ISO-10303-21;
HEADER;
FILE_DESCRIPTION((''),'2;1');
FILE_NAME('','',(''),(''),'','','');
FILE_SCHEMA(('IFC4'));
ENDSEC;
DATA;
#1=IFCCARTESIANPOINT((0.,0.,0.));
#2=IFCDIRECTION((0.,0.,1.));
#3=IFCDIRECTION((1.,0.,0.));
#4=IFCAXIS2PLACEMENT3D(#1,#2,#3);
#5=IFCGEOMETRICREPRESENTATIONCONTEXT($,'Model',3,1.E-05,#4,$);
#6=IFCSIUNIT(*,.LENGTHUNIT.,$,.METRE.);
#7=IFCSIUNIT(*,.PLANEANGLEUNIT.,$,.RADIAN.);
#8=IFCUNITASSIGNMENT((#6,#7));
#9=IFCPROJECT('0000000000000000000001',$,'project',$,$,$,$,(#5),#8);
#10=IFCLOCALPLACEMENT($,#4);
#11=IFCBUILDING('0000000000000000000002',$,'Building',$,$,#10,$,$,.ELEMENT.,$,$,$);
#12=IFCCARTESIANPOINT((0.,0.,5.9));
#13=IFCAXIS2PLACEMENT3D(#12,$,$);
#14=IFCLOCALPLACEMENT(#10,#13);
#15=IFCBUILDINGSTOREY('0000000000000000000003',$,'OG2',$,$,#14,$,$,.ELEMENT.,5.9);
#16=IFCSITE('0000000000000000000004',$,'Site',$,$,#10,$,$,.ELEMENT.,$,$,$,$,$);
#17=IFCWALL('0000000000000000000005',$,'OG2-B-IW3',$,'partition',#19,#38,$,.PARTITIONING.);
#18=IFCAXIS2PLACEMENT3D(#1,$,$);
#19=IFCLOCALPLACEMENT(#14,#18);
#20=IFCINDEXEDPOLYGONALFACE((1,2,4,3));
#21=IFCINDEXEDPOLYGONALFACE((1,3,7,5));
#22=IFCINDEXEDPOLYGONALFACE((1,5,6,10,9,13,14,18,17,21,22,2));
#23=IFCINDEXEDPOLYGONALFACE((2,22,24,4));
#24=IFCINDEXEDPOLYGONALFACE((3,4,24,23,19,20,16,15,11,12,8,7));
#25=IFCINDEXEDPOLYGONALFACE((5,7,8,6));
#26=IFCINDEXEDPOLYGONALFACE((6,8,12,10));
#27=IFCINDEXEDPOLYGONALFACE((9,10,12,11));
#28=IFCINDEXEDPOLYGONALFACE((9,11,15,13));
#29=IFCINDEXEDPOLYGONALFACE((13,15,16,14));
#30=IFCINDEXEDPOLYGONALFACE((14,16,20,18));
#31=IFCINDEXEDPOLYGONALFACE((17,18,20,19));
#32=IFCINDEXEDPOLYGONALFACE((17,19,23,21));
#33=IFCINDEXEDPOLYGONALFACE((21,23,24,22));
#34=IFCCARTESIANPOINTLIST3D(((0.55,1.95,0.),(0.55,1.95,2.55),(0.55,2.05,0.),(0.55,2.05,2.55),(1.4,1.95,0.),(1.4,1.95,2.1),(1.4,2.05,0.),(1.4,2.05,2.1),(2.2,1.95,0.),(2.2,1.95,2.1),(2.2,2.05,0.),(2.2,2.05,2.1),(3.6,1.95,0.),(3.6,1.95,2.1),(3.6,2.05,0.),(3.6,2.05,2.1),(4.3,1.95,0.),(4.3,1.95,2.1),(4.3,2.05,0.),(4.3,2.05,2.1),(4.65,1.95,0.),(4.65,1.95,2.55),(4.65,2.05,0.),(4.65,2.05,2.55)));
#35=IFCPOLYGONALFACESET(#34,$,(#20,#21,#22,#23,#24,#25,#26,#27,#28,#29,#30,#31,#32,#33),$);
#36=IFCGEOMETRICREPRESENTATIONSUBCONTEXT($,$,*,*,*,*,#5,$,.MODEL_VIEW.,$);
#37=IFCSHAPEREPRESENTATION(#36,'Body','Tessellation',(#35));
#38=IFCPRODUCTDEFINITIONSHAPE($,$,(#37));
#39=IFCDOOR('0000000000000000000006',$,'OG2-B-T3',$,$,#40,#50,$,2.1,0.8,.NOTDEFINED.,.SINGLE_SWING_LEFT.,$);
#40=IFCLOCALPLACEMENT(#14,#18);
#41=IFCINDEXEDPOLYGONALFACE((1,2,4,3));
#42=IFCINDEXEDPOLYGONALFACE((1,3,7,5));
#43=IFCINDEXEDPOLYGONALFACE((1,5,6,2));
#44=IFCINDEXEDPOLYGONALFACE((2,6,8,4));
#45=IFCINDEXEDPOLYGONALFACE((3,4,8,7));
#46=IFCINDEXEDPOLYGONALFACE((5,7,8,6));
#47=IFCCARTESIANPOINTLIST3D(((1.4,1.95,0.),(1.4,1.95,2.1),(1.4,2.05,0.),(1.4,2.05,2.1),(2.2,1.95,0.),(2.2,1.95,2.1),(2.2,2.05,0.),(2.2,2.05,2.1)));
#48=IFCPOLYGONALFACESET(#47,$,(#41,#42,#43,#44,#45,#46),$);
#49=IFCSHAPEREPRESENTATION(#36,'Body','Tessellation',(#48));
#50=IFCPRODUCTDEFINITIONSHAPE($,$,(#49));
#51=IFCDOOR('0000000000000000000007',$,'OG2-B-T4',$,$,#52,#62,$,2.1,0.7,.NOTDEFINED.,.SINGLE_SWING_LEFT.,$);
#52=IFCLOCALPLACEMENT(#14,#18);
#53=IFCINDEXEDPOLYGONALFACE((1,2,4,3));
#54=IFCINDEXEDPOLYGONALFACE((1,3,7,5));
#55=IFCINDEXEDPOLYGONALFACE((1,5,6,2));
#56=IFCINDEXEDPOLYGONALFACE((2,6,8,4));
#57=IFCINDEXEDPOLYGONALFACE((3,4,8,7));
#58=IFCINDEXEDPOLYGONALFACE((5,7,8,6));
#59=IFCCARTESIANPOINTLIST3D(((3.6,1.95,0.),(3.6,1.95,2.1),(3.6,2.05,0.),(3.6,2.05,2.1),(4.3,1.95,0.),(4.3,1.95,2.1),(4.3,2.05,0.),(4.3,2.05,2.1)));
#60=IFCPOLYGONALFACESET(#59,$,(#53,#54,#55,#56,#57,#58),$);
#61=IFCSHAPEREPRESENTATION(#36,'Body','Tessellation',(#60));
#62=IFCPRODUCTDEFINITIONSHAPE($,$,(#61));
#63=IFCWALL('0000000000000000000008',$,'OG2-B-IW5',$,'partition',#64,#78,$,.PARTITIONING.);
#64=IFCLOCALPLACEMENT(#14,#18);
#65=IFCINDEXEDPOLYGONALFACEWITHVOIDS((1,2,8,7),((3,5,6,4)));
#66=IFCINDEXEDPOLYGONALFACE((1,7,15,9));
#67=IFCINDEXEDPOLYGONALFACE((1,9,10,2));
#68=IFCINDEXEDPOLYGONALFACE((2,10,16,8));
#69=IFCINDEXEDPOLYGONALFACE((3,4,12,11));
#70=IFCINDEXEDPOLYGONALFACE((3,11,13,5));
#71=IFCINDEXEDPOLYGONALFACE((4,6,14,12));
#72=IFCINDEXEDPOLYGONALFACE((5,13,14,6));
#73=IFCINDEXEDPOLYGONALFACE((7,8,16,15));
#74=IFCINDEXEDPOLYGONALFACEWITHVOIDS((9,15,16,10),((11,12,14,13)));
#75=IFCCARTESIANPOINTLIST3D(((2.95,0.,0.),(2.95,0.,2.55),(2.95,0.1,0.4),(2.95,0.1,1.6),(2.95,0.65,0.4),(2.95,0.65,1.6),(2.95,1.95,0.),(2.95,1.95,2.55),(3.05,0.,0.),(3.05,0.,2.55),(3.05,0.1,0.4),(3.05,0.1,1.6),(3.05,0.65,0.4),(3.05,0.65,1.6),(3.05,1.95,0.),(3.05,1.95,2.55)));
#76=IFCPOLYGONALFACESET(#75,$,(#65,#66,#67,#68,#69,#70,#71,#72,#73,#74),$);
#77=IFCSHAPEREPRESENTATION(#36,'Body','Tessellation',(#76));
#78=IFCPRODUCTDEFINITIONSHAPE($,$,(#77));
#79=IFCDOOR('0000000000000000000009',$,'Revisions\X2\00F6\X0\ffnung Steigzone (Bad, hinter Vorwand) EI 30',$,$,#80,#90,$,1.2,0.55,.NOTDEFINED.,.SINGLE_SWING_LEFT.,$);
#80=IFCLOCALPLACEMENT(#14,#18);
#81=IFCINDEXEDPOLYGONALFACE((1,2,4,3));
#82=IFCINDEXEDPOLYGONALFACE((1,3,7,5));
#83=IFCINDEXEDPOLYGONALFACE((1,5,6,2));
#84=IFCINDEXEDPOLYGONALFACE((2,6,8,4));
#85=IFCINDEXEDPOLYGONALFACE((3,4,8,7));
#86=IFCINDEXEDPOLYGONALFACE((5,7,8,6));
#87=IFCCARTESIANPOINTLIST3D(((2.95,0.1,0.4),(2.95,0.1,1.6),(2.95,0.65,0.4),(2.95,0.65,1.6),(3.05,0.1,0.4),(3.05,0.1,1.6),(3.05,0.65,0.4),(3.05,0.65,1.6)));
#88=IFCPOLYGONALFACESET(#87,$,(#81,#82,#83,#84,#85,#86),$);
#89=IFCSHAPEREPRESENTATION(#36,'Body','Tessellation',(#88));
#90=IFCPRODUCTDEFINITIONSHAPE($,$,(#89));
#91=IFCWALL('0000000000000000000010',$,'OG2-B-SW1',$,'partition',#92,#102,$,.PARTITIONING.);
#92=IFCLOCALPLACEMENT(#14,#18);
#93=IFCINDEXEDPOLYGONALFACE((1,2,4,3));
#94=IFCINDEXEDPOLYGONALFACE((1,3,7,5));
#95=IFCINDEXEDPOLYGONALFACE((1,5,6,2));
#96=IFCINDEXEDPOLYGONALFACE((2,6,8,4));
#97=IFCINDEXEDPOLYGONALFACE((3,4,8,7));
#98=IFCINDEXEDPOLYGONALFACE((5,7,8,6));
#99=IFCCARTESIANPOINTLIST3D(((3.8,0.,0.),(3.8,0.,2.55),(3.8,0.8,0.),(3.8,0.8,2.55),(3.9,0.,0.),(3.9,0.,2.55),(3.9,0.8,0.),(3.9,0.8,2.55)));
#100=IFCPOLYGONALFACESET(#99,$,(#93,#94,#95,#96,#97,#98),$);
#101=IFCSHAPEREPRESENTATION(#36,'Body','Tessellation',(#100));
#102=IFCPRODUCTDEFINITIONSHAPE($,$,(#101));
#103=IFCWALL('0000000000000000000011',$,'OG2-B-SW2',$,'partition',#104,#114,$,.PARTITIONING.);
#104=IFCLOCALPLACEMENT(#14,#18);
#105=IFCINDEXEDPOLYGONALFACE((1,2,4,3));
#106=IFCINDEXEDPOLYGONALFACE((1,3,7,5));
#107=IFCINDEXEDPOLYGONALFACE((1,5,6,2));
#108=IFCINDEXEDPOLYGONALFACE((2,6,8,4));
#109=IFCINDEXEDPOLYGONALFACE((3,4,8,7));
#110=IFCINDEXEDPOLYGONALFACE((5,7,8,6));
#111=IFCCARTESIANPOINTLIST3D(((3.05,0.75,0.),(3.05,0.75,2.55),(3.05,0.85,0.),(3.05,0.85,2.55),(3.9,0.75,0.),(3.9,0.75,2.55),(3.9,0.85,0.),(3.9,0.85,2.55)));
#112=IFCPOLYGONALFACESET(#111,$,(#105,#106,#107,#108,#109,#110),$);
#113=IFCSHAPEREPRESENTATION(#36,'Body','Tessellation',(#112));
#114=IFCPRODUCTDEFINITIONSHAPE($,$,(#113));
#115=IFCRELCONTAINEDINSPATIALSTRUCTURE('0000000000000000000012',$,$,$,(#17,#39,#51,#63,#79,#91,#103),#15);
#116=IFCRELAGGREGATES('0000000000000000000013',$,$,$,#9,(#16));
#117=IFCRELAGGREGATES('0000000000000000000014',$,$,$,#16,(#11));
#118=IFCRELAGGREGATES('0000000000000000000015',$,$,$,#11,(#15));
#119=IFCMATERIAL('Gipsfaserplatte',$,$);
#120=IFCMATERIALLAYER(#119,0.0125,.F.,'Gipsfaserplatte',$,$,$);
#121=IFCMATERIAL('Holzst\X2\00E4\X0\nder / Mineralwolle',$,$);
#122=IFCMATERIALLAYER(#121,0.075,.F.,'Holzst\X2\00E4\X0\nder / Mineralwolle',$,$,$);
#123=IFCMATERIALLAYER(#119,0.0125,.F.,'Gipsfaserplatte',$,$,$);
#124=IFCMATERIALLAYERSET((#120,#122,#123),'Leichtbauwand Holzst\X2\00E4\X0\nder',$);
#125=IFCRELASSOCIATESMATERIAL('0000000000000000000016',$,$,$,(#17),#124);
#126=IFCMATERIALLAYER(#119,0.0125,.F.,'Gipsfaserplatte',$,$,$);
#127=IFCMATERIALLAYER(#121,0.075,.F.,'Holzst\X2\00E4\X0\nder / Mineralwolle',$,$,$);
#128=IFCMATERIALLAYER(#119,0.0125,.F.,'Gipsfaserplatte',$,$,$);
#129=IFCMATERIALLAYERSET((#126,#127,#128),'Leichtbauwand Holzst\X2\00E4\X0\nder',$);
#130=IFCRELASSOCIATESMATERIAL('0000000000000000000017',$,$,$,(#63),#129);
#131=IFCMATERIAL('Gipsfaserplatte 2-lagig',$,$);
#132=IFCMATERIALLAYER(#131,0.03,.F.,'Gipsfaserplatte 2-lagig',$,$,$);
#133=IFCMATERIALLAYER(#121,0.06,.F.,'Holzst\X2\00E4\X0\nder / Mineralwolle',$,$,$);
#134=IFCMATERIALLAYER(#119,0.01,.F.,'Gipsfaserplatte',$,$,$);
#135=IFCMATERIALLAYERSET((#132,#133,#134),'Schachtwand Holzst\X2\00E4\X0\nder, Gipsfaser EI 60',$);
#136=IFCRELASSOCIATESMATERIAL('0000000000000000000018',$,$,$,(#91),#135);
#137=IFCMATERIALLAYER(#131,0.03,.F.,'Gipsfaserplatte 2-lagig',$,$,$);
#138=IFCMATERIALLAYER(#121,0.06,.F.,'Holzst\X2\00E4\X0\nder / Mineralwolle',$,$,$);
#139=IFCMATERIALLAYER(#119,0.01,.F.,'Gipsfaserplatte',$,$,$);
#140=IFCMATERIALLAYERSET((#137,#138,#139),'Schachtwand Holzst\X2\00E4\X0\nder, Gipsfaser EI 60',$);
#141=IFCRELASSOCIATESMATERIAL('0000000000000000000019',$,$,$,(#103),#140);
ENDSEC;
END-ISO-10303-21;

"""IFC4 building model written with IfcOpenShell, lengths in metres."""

from ifc_helpers import new_model, si_unit, frame, frame_2d, origin, origin_with_axes, place, context, subcontext, project, spatial, rectangle, extrude, material, layer, layer_set, element, fill, save


model = new_model("IFC4")

# Units and contexts
model_context = context("Model", 3, precision=1e-05, world=origin_with_axes())
sub_context = subcontext(model_context, None, None, "MODEL_VIEW")
ifc_project = project(units=[si_unit("LENGTHUNIT", "METRE"), si_unit("PLANEANGLEUNIT", "RADIAN")], contexts=[model_context])

# Site, building, storey
placement = place(None, origin_with_axes())
site = spatial("IfcSite", under=ifc_project, at=placement, Name="Site", CompositionType="ELEMENT")
building = spatial("IfcBuilding", under=site, at=placement, Name="Building", CompositionType="ELEMENT")
storey_placement = place(placement, frame((0.0, 0.0, 5.9)))
storey = spatial("IfcBuildingStorey", under=building, at=storey_placement, Name="OG2", CompositionType="ELEMENT", Elevation=5.9)

# Shared definitions
ifc_material_1 = material(Name="Gipsfaserplatte")

# Shared definitions
ifc_material_2 = material(Name="Gipsfaserplatte 2-lagig")

# Shared definitions
ifc_material_3 = material(Name="Holzständer / Mineralwolle")

# Wall, openings, doors
ifc_layer_1 = layer(ifc_material_1, 0.0125, ventilated=False, Name="Gipsfaserplatte")
ifc_layer_2 = layer(ifc_material_3, 0.075, ventilated=False, Name="Holzständer / Mineralwolle")
ifc_layer_3 = layer(ifc_material_1, 0.0125, ventilated=False, Name="Gipsfaserplatte")
ifc_layer_set_1 = layer_set([ifc_layer_1, ifc_layer_2, ifc_layer_3], Name="Leichtbauwand Holzständer")
wall_1_placement = place(storey_placement, frame((0.55, 2.0, 0.0), z_axis=(0.0, 0.0, 1.0), x_axis=(1.0, 0.0, 0.0)))
wall_1 = element("IfcWall", 1, at=wall_1_placement, inside=storey, material=ifc_layer_set_1, Name="OG2-B-IW3", ObjectType="partition", PredefinedType="PARTITIONING", context=sub_context, shape_type="SweptSolid", body=[
    extrude(rectangle(XDim=4.1, YDim=0.1, at=frame_2d((2.05, 0.0))), origin(), (0.0, 0.0, 1.0), 2.55),
])
opening_1_placement = place(wall_1_placement, frame((1.25, 0.1, 0.0), z_axis=(0.0, -1.0, 0.0), x_axis=(1.0, 0.0, 0.0)))
opening_1 = element("IfcOpeningElement", 2, at=opening_1_placement, cuts=wall_1, PredefinedType="OPENING", context=sub_context, shape_type="SweptSolid", body=[
    extrude(rectangle(XDim=0.8, YDim=2.1, at=frame_2d((0.0, 1.05))), origin(), (0.0, 0.0, 1.0), 0.2),
])
opening_2_placement = place(wall_1_placement, frame((3.4, 0.1, 0.0), z_axis=(0.0, -1.0, 0.0), x_axis=(1.0, 0.0, 0.0)))
opening_2 = element("IfcOpeningElement", 3, at=opening_2_placement, cuts=wall_1, PredefinedType="OPENING", context=sub_context, shape_type="SweptSolid", body=[
    extrude(rectangle(XDim=0.7, YDim=2.1, at=frame_2d((0.0, 1.05))), origin(), (0.0, 0.0, 1.0), 0.2),
])
door_1_placement = place(wall_1_placement, frame((1.25, 0.05, 0.0), z_axis=(0.0, -1.0, 0.0), x_axis=(1.0, 0.0, 0.0)))
door_1 = element("IfcDoor", 4, at=door_1_placement, inside=storey, Name="OG2-B-T3", OperationType="SINGLE_SWING_LEFT", OverallHeight=2.1, OverallWidth=0.8, PredefinedType="NOTDEFINED", context=sub_context, shape_type="SweptSolid", body=[
    extrude(rectangle(XDim=0.8, YDim=2.1, at=frame_2d((0.0, 1.05))), origin(), (0.0, 0.0, 1.0), 0.1),
])
fill(opening_1, door_1)
door_2_placement = place(wall_1_placement, frame((3.4, 0.05, 0.0), z_axis=(0.0, -1.0, 0.0), x_axis=(1.0, 0.0, 0.0)))
door_2 = element("IfcDoor", 5, at=door_2_placement, inside=storey, Name="OG2-B-T4", OperationType="SINGLE_SWING_LEFT", OverallHeight=2.1, OverallWidth=0.7, PredefinedType="NOTDEFINED", context=sub_context, shape_type="SweptSolid", body=[
    extrude(rectangle(XDim=0.7, YDim=2.1, at=frame_2d((0.0, 1.05))), origin(), (0.0, 0.0, 1.0), 0.1),
])
fill(opening_2, door_2)

# Wall, opening, door
ifc_layer_4 = layer(ifc_material_1, 0.0125, ventilated=False, Name="Gipsfaserplatte")
ifc_layer_5 = layer(ifc_material_3, 0.075, ventilated=False, Name="Holzständer / Mineralwolle")
ifc_layer_6 = layer(ifc_material_1, 0.0125, ventilated=False, Name="Gipsfaserplatte")
ifc_layer_set_2 = layer_set([ifc_layer_4, ifc_layer_5, ifc_layer_6], Name="Leichtbauwand Holzständer")
wall_2_placement = place(storey_placement, frame((3.0, 0.0, 0.0), z_axis=(0.0, 0.0, 1.0), x_axis=(0.0, 1.0, 0.0)))
wall_2 = element("IfcWall", 6, at=wall_2_placement, inside=storey, material=ifc_layer_set_2, Name="OG2-B-IW5", ObjectType="partition", PredefinedType="PARTITIONING", context=sub_context, shape_type="SweptSolid", body=[
    extrude(rectangle(XDim=1.95, YDim=0.1, at=frame_2d((0.975, 0.0))), origin(), (0.0, 0.0, 1.0), 2.55),
])
opening_3_placement = place(wall_2_placement, frame((0.375, 0.1, 0.4), z_axis=(0.0, -1.0, 0.0), x_axis=(1.0, 0.0, 0.0)))
opening_3 = element("IfcOpeningElement", 7, at=opening_3_placement, cuts=wall_2, PredefinedType="OPENING", context=sub_context, shape_type="SweptSolid", body=[
    extrude(rectangle(XDim=0.55, YDim=1.2, at=frame_2d((0.0, 0.6))), origin(), (0.0, 0.0, 1.0), 0.2),
])
door_3_placement = place(wall_2_placement, frame((0.375, 0.05, 0.4), z_axis=(0.0, -1.0, 0.0), x_axis=(1.0, 0.0, 0.0)))
door_3 = element("IfcDoor", 8, at=door_3_placement, inside=storey, Name="Revisionsöffnung Steigzone (Bad, hinter Vorwand) EI 30", OperationType="SINGLE_SWING_LEFT", OverallHeight=1.2, OverallWidth=0.55, PredefinedType="NOTDEFINED", context=sub_context, shape_type="SweptSolid", body=[
    extrude(rectangle(XDim=0.55, YDim=1.2, at=frame_2d((0.0, 0.6))), origin(), (0.0, 0.0, 1.0), 0.1),
])
fill(opening_3, door_3)

# Walls
ifc_layer_7 = layer(ifc_material_2, 0.03, ventilated=False, Name="Gipsfaserplatte 2-lagig")
ifc_layer_8 = layer(ifc_material_3, 0.06, ventilated=False, Name="Holzständer / Mineralwolle")
ifc_layer_9 = layer(ifc_material_1, 0.01, ventilated=False, Name="Gipsfaserplatte")
ifc_layer_set_3 = layer_set([ifc_layer_7, ifc_layer_8, ifc_layer_9], Name="Schachtwand Holzständer, Gipsfaser EI 60")
wall_3_placement = place(storey_placement, frame((3.85, 0.0, 0.0), z_axis=(0.0, 0.0, 1.0), x_axis=(0.0, 1.0, 0.0)))
element("IfcWall", 9, at=wall_3_placement, inside=storey, material=ifc_layer_set_3, Name="OG2-B-SW1", ObjectType="partition", PredefinedType="PARTITIONING", context=sub_context, shape_type="SweptSolid", body=[
    extrude(rectangle(XDim=0.8, YDim=0.1, at=frame_2d((0.4, 0.0))), origin(), (0.0, 0.0, 1.0), 2.55),
])
ifc_layer_10 = layer(ifc_material_2, 0.03, ventilated=False, Name="Gipsfaserplatte 2-lagig")
ifc_layer_11 = layer(ifc_material_3, 0.06, ventilated=False, Name="Holzständer / Mineralwolle")
ifc_layer_12 = layer(ifc_material_1, 0.01, ventilated=False, Name="Gipsfaserplatte")
ifc_layer_set_4 = layer_set([ifc_layer_10, ifc_layer_11, ifc_layer_12], Name="Schachtwand Holzständer, Gipsfaser EI 60")
wall_4_placement = place(storey_placement, frame((3.05, 0.8, 0.0), z_axis=(0.0, 0.0, 1.0), x_axis=(1.0, 0.0, 0.0)))
element("IfcWall", 10, at=wall_4_placement, inside=storey, material=ifc_layer_set_4, Name="OG2-B-SW2", ObjectType="partition", PredefinedType="PARTITIONING", context=sub_context, shape_type="SweptSolid", body=[
    extrude(rectangle(XDim=0.85, YDim=0.1, at=frame_2d((0.425, 0.0))), origin(), (0.0, 0.0, 1.0), 2.55),
])

save(model, "model.ifc")
